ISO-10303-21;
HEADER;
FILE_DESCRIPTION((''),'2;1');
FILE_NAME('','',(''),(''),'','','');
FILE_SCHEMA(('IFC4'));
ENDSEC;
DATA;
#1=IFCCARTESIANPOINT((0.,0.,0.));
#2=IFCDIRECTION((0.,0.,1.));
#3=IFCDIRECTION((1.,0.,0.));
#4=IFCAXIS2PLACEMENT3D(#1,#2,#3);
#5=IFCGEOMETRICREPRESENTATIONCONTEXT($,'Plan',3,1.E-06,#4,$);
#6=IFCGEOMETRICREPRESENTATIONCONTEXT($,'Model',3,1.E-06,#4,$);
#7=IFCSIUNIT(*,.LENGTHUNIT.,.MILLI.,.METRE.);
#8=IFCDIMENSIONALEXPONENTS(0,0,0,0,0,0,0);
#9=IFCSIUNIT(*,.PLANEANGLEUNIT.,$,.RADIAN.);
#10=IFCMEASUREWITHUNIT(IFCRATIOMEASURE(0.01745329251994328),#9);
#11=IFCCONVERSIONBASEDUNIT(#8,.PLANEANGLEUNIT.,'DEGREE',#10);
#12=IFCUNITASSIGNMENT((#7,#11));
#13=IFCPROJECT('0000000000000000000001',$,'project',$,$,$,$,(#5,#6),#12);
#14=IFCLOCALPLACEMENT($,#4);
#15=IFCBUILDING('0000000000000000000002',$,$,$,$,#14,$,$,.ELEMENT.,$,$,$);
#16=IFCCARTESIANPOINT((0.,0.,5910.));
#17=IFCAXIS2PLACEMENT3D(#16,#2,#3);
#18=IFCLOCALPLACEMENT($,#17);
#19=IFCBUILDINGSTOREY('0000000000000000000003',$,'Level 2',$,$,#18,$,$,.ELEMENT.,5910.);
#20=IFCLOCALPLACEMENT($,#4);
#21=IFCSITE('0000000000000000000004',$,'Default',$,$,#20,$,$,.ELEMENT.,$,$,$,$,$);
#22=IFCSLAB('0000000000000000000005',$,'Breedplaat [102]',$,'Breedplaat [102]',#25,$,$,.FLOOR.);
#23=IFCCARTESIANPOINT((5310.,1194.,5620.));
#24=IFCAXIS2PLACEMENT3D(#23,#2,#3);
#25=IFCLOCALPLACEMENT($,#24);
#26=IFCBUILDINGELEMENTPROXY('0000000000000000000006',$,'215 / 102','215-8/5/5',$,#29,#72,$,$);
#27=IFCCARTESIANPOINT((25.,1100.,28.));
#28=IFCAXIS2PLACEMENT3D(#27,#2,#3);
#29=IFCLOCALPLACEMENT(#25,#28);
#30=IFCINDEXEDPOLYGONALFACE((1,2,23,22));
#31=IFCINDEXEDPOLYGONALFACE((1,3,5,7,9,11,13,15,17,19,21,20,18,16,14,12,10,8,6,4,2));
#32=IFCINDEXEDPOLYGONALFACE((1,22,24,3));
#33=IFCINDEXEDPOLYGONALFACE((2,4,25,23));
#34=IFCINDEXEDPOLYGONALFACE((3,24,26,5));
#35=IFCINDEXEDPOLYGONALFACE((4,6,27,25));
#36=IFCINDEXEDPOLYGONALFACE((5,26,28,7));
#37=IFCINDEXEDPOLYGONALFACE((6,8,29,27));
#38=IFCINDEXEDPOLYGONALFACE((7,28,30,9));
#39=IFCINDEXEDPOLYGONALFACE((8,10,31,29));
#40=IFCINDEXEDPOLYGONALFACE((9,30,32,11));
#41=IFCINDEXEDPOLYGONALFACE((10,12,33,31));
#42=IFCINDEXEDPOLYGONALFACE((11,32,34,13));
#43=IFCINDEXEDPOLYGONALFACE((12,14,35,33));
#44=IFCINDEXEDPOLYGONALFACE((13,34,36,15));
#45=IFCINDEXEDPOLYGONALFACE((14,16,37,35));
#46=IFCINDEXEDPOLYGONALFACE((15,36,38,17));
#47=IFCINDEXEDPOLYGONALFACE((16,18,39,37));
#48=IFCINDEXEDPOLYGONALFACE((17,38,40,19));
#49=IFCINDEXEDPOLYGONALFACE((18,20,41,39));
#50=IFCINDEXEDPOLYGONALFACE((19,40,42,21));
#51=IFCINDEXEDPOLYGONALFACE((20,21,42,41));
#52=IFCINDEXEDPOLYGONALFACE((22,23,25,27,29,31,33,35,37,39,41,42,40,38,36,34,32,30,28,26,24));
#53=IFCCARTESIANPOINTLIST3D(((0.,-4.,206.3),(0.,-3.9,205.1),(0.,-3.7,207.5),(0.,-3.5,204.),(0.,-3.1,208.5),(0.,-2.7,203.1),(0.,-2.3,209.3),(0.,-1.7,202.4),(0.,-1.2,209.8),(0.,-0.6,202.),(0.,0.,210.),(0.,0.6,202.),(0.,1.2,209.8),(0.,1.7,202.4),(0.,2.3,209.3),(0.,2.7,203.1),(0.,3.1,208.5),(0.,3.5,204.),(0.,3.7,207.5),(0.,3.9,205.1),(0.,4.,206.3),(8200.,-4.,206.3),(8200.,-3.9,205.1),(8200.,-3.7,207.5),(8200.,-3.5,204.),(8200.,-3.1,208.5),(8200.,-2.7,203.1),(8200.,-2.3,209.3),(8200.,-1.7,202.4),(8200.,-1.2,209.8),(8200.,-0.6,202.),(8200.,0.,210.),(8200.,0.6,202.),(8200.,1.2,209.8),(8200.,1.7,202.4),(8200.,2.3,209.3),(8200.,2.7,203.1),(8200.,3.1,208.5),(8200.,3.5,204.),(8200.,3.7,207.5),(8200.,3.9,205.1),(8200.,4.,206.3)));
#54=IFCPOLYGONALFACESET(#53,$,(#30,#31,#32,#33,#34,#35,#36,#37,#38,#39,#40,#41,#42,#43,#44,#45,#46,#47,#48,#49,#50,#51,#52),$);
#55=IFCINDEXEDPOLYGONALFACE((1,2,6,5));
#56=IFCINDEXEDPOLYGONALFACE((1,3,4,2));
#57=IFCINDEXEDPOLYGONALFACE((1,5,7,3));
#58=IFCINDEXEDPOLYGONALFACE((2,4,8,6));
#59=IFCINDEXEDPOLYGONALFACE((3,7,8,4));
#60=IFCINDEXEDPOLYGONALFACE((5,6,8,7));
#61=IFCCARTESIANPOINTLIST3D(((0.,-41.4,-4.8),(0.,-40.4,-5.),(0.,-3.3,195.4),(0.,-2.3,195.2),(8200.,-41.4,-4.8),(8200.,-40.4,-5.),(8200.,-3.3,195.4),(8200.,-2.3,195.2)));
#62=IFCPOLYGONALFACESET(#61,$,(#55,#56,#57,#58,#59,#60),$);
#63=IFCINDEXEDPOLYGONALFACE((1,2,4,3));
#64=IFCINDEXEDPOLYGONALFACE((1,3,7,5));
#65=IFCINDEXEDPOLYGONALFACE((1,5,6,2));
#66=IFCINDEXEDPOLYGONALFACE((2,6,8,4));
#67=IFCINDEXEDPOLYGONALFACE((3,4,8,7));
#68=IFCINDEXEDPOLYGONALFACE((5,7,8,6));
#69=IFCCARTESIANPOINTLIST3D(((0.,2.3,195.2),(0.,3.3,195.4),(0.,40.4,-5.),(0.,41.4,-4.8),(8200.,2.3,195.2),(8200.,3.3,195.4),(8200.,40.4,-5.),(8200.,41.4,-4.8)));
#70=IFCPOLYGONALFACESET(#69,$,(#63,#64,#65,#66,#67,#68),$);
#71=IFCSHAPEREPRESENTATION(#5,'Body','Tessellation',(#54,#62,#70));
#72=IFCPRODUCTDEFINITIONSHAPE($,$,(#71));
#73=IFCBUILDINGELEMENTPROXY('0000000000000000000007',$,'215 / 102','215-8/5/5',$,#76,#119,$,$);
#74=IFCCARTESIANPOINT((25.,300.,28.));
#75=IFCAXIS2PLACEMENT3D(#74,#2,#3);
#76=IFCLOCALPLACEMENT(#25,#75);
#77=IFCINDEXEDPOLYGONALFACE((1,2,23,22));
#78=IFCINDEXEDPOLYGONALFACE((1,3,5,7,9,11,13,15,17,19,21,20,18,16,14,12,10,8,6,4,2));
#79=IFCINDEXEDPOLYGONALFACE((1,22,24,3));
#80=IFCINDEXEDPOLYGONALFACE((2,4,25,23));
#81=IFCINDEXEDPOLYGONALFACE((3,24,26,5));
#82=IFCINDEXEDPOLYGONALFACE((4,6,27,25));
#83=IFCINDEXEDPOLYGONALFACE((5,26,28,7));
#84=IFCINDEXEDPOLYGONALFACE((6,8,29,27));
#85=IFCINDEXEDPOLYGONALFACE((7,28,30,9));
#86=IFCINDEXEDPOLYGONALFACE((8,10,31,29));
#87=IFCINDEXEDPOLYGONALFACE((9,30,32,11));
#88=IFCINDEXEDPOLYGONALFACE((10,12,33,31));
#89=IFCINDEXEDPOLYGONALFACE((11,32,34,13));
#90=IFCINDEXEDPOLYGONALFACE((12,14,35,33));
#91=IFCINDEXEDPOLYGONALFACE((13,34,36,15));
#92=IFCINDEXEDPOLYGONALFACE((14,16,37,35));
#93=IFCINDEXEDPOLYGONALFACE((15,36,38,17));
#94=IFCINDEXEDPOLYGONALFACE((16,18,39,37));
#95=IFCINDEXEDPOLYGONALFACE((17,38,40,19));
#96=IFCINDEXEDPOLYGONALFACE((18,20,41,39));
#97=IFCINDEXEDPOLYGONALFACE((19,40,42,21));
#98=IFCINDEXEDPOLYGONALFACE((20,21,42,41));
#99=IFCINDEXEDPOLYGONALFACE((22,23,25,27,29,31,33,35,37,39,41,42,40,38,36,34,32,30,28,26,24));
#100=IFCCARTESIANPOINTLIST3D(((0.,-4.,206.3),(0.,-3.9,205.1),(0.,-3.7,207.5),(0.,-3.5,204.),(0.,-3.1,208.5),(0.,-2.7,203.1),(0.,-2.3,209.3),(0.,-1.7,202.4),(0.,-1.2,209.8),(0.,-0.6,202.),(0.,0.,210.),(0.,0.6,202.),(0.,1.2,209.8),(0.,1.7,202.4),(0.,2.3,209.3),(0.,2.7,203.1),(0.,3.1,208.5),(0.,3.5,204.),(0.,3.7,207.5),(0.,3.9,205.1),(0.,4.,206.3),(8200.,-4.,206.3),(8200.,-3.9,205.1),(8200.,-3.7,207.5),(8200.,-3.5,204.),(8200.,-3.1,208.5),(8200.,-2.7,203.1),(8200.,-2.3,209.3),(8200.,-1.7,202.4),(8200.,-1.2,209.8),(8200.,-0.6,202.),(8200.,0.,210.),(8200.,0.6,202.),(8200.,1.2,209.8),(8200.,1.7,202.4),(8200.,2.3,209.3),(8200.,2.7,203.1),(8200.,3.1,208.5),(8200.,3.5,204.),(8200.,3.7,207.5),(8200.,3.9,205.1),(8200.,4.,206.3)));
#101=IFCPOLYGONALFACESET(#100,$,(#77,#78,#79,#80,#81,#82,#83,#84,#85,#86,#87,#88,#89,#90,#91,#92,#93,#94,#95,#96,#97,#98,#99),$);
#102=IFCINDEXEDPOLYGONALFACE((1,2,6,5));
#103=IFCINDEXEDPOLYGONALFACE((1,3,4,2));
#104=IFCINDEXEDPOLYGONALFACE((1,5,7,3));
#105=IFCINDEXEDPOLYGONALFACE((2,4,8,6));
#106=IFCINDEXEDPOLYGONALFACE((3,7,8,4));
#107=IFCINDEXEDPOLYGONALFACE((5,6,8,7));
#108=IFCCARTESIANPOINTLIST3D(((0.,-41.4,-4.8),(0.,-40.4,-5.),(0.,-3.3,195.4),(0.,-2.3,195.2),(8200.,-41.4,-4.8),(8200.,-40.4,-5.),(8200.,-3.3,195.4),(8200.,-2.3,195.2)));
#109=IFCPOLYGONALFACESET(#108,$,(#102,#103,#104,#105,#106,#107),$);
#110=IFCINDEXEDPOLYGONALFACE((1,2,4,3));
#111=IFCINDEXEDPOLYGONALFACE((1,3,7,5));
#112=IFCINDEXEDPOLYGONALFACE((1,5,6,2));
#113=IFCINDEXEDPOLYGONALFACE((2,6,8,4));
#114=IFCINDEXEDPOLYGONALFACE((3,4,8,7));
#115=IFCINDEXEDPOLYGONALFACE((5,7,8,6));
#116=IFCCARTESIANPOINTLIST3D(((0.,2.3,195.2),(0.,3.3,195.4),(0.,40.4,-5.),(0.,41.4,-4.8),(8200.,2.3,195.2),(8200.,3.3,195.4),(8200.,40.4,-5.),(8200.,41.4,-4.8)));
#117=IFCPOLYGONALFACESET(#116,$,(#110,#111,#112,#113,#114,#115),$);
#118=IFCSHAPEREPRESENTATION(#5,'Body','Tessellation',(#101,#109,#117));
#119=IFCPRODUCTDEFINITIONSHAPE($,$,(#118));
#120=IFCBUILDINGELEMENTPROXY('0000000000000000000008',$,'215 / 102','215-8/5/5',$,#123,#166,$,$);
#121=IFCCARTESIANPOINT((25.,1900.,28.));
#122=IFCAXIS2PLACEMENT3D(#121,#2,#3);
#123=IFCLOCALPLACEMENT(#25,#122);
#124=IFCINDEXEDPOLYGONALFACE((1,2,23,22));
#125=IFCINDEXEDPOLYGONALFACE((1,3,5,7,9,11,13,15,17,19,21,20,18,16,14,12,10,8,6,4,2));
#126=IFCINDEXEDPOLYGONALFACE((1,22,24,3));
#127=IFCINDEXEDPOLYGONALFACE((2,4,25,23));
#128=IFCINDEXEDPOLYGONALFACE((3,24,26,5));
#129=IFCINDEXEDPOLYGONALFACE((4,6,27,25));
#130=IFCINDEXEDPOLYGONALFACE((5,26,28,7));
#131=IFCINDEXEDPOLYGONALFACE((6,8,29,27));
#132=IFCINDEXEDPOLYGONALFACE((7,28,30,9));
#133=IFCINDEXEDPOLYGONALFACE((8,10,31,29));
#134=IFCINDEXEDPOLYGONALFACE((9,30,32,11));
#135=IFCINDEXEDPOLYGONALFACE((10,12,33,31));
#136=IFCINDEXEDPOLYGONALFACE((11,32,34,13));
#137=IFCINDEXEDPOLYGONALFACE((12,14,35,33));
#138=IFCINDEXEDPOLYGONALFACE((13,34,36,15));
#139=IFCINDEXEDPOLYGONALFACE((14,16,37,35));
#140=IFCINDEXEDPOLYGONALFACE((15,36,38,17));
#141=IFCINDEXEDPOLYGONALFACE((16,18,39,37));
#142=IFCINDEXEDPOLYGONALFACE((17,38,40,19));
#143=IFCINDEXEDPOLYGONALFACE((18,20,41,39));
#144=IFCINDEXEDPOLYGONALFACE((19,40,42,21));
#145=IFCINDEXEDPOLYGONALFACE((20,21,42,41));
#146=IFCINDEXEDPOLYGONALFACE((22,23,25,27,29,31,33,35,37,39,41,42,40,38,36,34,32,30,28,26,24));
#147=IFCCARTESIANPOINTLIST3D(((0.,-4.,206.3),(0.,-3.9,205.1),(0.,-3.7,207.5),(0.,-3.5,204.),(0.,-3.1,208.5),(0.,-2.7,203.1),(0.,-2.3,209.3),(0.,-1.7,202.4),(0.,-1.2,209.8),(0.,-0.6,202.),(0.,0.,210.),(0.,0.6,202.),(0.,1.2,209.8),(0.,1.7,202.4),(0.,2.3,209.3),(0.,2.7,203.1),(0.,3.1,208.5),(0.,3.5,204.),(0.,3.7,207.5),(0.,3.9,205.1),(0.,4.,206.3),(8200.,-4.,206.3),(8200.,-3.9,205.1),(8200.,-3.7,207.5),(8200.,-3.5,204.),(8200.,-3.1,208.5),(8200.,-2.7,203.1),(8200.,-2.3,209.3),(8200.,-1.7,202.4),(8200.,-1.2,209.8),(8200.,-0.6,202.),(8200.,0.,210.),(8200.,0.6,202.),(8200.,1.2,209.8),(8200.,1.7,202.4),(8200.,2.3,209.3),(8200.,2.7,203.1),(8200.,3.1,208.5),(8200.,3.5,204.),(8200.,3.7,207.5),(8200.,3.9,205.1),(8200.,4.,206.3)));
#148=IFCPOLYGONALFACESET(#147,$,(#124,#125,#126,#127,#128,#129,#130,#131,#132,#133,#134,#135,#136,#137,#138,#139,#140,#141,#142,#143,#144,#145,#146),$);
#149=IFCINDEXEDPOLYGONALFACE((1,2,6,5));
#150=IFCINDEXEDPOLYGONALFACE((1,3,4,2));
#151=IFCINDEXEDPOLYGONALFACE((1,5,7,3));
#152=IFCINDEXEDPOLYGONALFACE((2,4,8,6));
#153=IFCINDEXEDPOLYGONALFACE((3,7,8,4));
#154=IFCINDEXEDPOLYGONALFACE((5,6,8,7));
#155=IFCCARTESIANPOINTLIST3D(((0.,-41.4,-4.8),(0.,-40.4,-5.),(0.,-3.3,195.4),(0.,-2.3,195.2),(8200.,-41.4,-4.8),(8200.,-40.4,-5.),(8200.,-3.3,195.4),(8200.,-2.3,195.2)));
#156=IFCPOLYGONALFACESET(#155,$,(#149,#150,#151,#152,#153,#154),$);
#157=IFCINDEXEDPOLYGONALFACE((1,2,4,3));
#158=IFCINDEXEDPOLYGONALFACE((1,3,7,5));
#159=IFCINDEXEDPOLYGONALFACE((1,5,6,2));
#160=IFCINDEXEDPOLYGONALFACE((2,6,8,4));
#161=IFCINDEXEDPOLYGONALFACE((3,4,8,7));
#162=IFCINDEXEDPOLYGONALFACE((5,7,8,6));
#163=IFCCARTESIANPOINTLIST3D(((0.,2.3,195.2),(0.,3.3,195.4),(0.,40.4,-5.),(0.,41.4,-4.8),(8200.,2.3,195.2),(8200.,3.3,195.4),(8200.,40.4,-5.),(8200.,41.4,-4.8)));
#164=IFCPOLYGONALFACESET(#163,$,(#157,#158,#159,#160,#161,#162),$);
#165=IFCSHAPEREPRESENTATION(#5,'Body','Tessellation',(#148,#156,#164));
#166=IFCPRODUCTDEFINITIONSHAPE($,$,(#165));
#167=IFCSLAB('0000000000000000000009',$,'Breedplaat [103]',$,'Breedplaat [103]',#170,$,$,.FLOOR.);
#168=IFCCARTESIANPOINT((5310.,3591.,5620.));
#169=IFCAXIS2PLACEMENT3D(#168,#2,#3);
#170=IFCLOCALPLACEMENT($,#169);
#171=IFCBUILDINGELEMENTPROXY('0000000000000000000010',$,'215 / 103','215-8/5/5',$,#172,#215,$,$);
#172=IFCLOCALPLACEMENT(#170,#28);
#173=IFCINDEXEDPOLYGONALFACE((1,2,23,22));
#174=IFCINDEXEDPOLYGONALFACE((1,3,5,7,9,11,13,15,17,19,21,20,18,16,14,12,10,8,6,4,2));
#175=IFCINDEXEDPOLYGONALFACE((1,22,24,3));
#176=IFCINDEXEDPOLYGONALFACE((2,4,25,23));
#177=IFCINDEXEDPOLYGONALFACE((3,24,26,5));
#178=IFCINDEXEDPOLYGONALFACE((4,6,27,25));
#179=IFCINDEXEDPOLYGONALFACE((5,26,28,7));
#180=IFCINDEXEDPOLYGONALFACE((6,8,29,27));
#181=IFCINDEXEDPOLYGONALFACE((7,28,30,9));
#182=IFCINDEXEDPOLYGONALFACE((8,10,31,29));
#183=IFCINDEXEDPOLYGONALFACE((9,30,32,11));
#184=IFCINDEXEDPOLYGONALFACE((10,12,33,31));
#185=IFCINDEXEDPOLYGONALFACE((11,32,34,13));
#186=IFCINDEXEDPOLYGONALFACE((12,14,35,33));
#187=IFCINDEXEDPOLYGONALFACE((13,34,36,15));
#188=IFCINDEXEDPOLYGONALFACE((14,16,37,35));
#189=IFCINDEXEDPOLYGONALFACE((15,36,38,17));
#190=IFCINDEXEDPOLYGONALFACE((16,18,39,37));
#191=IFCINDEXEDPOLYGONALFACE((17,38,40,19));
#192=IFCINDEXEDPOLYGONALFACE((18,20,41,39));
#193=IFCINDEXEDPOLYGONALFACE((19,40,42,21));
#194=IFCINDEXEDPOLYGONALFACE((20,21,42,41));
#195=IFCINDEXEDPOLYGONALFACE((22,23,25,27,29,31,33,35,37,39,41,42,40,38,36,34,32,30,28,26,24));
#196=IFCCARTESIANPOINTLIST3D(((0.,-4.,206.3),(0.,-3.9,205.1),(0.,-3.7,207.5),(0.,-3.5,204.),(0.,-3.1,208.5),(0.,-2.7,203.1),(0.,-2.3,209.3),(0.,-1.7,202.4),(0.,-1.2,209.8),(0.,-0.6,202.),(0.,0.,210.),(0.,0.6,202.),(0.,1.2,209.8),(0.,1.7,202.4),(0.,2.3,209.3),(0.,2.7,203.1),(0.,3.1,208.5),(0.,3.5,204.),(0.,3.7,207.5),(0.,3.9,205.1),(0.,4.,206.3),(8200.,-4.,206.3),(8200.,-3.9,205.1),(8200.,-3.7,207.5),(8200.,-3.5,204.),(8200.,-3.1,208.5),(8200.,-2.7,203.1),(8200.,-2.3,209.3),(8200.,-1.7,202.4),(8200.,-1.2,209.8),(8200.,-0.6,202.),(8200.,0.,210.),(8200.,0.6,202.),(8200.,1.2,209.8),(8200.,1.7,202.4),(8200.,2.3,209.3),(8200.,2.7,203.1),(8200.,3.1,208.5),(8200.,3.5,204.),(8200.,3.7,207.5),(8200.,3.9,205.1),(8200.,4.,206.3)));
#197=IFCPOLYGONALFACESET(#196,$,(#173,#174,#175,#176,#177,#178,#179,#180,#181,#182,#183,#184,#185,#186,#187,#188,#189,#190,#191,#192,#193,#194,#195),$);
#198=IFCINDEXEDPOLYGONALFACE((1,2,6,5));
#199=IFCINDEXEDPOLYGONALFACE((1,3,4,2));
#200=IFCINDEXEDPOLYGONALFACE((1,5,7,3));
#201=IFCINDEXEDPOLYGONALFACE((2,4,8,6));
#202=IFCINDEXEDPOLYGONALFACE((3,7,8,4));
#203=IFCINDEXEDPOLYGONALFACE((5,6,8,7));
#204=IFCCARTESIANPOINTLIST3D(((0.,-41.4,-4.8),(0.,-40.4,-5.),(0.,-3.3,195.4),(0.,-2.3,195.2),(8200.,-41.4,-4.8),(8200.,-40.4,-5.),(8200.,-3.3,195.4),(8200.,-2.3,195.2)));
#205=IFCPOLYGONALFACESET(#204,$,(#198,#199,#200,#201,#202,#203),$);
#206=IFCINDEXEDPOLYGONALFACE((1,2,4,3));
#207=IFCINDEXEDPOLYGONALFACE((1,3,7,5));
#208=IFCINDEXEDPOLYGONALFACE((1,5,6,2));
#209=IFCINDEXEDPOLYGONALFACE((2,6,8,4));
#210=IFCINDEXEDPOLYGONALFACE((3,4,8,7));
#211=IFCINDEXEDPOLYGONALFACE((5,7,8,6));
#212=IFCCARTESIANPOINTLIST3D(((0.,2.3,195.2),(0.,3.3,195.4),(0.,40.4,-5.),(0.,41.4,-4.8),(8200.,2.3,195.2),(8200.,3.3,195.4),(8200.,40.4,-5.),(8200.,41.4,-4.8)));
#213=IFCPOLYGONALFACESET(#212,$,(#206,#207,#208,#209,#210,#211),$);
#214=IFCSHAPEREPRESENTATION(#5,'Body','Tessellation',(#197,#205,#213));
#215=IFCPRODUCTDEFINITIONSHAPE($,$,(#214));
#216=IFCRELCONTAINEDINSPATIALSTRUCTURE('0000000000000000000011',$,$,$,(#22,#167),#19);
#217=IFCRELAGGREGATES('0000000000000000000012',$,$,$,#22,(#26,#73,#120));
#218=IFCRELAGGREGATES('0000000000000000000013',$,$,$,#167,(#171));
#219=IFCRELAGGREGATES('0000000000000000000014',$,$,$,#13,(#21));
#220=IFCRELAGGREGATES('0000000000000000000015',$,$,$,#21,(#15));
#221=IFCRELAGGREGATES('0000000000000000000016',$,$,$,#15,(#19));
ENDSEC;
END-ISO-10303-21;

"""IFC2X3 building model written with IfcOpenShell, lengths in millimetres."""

from ifc_helpers import new_model, entity, si_unit, converted_unit, frame, origin_with_axes, origin_2d_with_axis, place, context, project, spatial, rectangle, circle, extrude, element, aggregate, save


model = new_model("IFC2X3")

# Units and contexts
plan_context = context("Plan", 3, precision=1e-06, world=origin_with_axes())
model_context = context("Model", 3, precision=1e-06, world=origin_with_axes())
ifc_project = project(units=[si_unit("LENGTHUNIT", "METRE", prefix="MILLI"), converted_unit("PLANEANGLEUNIT", "DEGREE", entity("IfcRatioMeasure", 0.01745329251994328), si_unit("PLANEANGLEUNIT", "RADIAN"), dimensions=[0, 0, 0, 0, 0, 0, 0])], contexts=[plan_context, model_context])

# Site, building, storey
site_placement = place(None, origin_with_axes())
site = spatial("IfcSite", under=ifc_project, at=site_placement, Name="Default", CompositionType="ELEMENT")
building_placement = place(None, origin_with_axes())
building = spatial("IfcBuilding", under=site, at=building_placement, CompositionType="ELEMENT")
storey_placement = place(None, frame((0.0, 0.0, 5910.0), z_axis=(0.0, 0.0, 1.0), x_axis=(1.0, 0.0, 0.0)))
storey = spatial("IfcBuildingStorey", under=building, at=storey_placement, Name="Level 2", CompositionType="ELEMENT", Elevation=5910.0)

# Slabs, building element proxies
slab_1_placement = place(None, frame((5310.0, 1194.0, 5620.0), z_axis=(0.0, 0.0, 1.0), x_axis=(1.0, 0.0, 0.0)))
slab_1 = element("IfcSlab", 1, at=slab_1_placement, inside=storey, Name="Breedplaat [102]", ObjectType="Breedplaat [102]", PredefinedType="FLOOR")
proxy_1_placement = place(slab_1_placement, frame((25.0, 1100.0, 28.0), z_axis=(0.0, 0.0, 1.0), x_axis=(1.0, 0.0, 0.0)))
proxy_1 = element("IfcBuildingElementProxy", 2, at=proxy_1_placement, Name="215 / 102", Description="215-8/5/5", context=plan_context, shape_type="SweptSolid", body=[
    extrude(circle(Radius=4.0, at=origin_2d_with_axis()), frame((0.0, 0.0, 206.0), z_axis=(1.0, 0.0, 0.0), x_axis=(0.0, 0.0, 1.0)), (0.0, 0.0, 1.0), 8200.0),
    extrude(rectangle(XDim=203.8, YDim=1.0, at=origin_2d_with_axis()), frame((0.0, -21.9, 95.2), z_axis=(1.0, 0.0, 0.0), x_axis=(0.0, 0.187112, 0.982339)), (0.0, 0.0, 1.0), 8200.0),
    extrude(rectangle(XDim=203.8, YDim=1.0, at=origin_2d_with_axis()), frame((0.0, 21.9, 95.2), z_axis=(1.0, 0.0, 0.0), x_axis=(0.0, -0.187112, 0.982339)), (0.0, 0.0, 1.0), 8200.0),
])
proxy_2_placement = place(slab_1_placement, frame((25.0, 300.0, 28.0), z_axis=(0.0, 0.0, 1.0), x_axis=(1.0, 0.0, 0.0)))
proxy_2 = element("IfcBuildingElementProxy", 3, at=proxy_2_placement, Name="215 / 102", Description="215-8/5/5", context=plan_context, shape_type="SweptSolid", body=[
    extrude(circle(Radius=4.0, at=origin_2d_with_axis()), frame((0.0, 0.0, 206.0), z_axis=(1.0, 0.0, 0.0), x_axis=(0.0, 0.0, 1.0)), (0.0, 0.0, 1.0), 8200.0),
    extrude(rectangle(XDim=203.8, YDim=1.0, at=origin_2d_with_axis()), frame((0.0, -21.9, 95.2), z_axis=(1.0, 0.0, 0.0), x_axis=(0.0, 0.187112, 0.982339)), (0.0, 0.0, 1.0), 8200.0),
    extrude(rectangle(XDim=203.8, YDim=1.0, at=origin_2d_with_axis()), frame((0.0, 21.9, 95.2), z_axis=(1.0, 0.0, 0.0), x_axis=(0.0, -0.187112, 0.982339)), (0.0, 0.0, 1.0), 8200.0),
])
proxy_3_placement = place(slab_1_placement, frame((25.0, 1900.0, 28.0), z_axis=(0.0, 0.0, 1.0), x_axis=(1.0, 0.0, 0.0)))
proxy_3 = element("IfcBuildingElementProxy", 4, at=proxy_3_placement, Name="215 / 102", Description="215-8/5/5", context=plan_context, shape_type="SweptSolid", body=[
    extrude(circle(Radius=4.0, at=origin_2d_with_axis()), frame((0.0, 0.0, 206.0), z_axis=(1.0, 0.0, 0.0), x_axis=(0.0, 0.0, 1.0)), (0.0, 0.0, 1.0), 8200.0),
    extrude(rectangle(XDim=203.8, YDim=1.0, at=origin_2d_with_axis()), frame((0.0, -21.9, 95.2), z_axis=(1.0, 0.0, 0.0), x_axis=(0.0, 0.187112, 0.982339)), (0.0, 0.0, 1.0), 8200.0),
    extrude(rectangle(XDim=203.8, YDim=1.0, at=origin_2d_with_axis()), frame((0.0, 21.9, 95.2), z_axis=(1.0, 0.0, 0.0), x_axis=(0.0, -0.187112, 0.982339)), (0.0, 0.0, 1.0), 8200.0),
])
aggregate(slab_1, [proxy_1, proxy_2, proxy_3])
slab_2_placement = place(None, frame((5310.0, 3591.0, 5620.0), z_axis=(0.0, 0.0, 1.0), x_axis=(1.0, 0.0, 0.0)))
slab_2 = element("IfcSlab", 5, at=slab_2_placement, inside=storey, Name="Breedplaat [103]", ObjectType="Breedplaat [103]", PredefinedType="FLOOR")
proxy_4_placement = place(slab_2_placement, frame((25.0, 1100.0, 28.0), z_axis=(0.0, 0.0, 1.0), x_axis=(1.0, 0.0, 0.0)))
proxy_4 = element("IfcBuildingElementProxy", 6, at=proxy_4_placement, Name="215 / 103", Description="215-8/5/5", context=plan_context, shape_type="SweptSolid", body=[
    extrude(circle(Radius=4.0, at=origin_2d_with_axis()), frame((0.0, 0.0, 206.0), z_axis=(1.0, 0.0, 0.0), x_axis=(0.0, 0.0, 1.0)), (0.0, 0.0, 1.0), 8200.0),
    extrude(rectangle(XDim=203.8, YDim=1.0, at=origin_2d_with_axis()), frame((0.0, -21.9, 95.2), z_axis=(1.0, 0.0, 0.0), x_axis=(0.0, 0.187112, 0.982339)), (0.0, 0.0, 1.0), 8200.0),
    extrude(rectangle(XDim=203.8, YDim=1.0, at=origin_2d_with_axis()), frame((0.0, 21.9, 95.2), z_axis=(1.0, 0.0, 0.0), x_axis=(0.0, -0.187112, 0.982339)), (0.0, 0.0, 1.0), 8200.0),
])
aggregate(slab_2, [proxy_4])

save(model, "model.ifc")
